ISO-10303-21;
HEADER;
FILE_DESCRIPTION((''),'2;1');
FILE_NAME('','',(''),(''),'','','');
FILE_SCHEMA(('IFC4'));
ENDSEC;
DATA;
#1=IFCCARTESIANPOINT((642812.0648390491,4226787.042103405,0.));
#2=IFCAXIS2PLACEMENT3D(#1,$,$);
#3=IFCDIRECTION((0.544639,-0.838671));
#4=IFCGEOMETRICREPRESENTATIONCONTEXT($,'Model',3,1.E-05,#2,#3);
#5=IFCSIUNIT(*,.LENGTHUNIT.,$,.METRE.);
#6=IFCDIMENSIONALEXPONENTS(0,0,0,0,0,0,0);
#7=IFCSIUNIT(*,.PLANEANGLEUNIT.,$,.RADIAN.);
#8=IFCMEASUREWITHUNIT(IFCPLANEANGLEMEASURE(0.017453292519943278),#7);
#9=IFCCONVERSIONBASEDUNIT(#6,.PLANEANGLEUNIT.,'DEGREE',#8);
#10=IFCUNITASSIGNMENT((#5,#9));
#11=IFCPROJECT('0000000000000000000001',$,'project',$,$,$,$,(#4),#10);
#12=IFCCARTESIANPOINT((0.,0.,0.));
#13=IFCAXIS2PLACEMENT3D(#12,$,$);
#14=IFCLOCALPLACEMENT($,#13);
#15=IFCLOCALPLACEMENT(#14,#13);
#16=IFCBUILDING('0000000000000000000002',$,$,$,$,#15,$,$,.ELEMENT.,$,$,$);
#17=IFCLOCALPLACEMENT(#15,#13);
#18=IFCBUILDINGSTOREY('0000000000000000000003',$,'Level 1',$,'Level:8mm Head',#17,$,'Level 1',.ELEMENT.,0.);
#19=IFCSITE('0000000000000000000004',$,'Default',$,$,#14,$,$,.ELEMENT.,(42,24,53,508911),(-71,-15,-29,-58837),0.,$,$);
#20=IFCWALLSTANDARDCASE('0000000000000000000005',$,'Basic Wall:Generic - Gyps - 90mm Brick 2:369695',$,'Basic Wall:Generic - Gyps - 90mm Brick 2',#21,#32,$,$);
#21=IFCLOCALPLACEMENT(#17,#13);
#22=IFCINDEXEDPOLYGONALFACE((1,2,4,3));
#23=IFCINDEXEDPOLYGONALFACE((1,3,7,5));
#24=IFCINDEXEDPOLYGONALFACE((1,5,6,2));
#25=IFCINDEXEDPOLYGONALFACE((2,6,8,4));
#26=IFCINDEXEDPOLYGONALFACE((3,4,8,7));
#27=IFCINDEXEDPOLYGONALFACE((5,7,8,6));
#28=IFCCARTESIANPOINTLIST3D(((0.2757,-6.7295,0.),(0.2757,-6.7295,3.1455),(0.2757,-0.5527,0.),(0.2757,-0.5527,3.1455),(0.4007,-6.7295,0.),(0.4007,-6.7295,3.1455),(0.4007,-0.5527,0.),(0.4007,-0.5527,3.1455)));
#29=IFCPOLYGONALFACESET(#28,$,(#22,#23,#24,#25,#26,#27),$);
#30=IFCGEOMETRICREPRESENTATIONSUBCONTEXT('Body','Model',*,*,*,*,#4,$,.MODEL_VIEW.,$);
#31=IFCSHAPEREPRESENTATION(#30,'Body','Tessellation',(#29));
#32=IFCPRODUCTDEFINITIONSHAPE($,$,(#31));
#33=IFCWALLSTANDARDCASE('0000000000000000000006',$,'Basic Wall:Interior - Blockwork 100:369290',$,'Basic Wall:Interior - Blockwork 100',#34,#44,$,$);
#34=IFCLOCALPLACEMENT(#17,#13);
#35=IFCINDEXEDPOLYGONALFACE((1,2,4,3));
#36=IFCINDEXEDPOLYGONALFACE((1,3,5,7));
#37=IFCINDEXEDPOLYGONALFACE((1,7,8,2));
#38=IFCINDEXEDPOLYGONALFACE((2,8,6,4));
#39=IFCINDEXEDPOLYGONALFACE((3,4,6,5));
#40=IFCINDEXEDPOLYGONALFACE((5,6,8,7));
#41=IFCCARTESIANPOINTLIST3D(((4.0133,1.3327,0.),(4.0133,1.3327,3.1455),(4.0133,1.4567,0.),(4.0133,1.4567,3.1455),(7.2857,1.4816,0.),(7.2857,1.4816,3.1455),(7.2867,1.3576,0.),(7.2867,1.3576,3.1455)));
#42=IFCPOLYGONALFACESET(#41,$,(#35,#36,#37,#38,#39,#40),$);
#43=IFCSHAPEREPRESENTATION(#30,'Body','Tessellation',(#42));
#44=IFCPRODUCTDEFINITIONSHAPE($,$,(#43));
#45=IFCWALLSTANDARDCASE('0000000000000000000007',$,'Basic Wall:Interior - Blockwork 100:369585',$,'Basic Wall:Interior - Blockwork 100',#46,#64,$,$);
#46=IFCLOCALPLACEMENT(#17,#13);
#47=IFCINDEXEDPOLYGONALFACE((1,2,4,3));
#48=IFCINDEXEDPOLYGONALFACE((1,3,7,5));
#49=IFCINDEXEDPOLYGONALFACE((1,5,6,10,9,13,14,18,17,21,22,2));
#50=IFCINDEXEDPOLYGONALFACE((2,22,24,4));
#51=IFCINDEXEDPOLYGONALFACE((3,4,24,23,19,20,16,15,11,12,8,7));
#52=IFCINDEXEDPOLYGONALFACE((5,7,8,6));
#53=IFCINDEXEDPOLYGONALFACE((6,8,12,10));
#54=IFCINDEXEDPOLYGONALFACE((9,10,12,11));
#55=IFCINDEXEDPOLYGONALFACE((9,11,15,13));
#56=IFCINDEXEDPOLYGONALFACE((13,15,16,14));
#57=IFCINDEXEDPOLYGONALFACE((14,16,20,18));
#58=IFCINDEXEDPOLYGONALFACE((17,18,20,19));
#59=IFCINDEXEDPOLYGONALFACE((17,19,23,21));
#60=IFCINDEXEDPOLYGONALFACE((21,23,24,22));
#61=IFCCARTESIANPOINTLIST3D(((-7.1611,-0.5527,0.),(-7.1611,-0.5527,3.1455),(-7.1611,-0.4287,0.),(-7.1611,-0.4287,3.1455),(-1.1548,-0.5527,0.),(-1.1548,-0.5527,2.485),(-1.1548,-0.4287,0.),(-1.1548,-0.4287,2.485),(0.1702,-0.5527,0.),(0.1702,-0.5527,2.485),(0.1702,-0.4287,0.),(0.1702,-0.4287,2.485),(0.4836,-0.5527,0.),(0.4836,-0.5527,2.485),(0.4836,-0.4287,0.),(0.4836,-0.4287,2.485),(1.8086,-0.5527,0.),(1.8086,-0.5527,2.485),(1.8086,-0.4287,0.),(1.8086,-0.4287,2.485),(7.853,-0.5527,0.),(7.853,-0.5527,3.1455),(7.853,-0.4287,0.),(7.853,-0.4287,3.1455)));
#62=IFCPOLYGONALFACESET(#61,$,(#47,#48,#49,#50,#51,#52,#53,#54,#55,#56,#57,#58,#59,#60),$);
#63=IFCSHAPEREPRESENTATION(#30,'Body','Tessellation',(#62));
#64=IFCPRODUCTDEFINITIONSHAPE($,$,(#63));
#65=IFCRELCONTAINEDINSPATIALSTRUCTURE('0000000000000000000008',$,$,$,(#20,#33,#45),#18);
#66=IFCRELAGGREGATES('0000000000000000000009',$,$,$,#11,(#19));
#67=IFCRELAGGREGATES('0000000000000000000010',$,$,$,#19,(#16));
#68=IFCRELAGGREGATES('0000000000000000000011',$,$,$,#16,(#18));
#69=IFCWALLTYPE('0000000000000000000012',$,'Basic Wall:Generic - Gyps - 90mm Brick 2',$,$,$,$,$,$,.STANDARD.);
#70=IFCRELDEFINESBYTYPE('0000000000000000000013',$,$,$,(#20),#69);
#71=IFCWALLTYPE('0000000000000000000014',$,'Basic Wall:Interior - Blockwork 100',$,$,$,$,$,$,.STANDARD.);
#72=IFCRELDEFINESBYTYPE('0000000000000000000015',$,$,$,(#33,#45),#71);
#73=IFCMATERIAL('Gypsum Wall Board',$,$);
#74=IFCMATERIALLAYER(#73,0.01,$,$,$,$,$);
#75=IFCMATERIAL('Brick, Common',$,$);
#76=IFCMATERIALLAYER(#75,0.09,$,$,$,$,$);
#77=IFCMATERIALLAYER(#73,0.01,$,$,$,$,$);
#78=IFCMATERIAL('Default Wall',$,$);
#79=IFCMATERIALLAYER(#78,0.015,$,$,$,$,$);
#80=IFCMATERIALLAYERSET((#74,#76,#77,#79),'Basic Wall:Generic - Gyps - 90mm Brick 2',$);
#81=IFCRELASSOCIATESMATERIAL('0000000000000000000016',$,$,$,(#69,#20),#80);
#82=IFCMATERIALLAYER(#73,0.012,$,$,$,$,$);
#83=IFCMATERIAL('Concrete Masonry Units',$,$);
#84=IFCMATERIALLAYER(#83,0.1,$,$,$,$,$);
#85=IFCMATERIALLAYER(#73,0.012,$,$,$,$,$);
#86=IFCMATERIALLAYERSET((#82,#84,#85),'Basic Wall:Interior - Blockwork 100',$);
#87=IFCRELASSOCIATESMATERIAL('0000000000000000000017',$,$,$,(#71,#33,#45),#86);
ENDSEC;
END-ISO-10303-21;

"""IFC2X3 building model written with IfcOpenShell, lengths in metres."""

from ifc_helpers import new_model, entity, si_unit, converted_unit, direction, frame, frame_2d, origin, place, context, subcontext, project, spatial, polyline, rectangle, outline, extrude, clip, bounded_halfspace, material, layer, layer_set, layer_usage, type_object, element, save


model = new_model("IFC2X3")

# Units and contexts
model_context = context("Model", 3, precision=1e-05, world=frame((642812.0648390491, 4226787.042103405, 0.0)), true_north=direction((0.544639, -0.838671)))
body_context = subcontext(model_context, "Body", "Model", "MODEL_VIEW")
ifc_project = project(units=[si_unit("LENGTHUNIT", "METRE"), converted_unit("PLANEANGLEUNIT", "DEGREE", entity("IfcPlaneAngleMeasure", 0.017453292519943278), si_unit("PLANEANGLEUNIT", "RADIAN"), dimensions=[0, 0, 0, 0, 0, 0, 0])], contexts=[model_context])

# Site, building, storey
site_placement = place(None, origin())
site = spatial("IfcSite", under=ifc_project, at=site_placement, Name="Default", CompositionType="ELEMENT", RefLatitude=(42, 24, 53, 508911), RefLongitude=(-71, -15, -29, -58837), RefElevation=0.0)
building_placement = place(site_placement, origin())
building = spatial("IfcBuilding", under=site, at=building_placement, CompositionType="ELEMENT")
storey_placement = place(building_placement, origin())
storey = spatial("IfcBuildingStorey", under=building, at=storey_placement, Name="Level 1", ObjectType="Level:8mm Head", LongName="Level 1", CompositionType="ELEMENT", Elevation=0.0)

# Shared definitions
ifc_material_1 = material(Name="Gypsum Wall Board")

# Shared definitions
ifc_material_2 = material(Name="Brick, Common")
ifc_material_3 = material(Name="Default Wall")

# Walls
ifc_layer_1 = layer(ifc_material_1, 0.01)
ifc_layer_2 = layer(ifc_material_2, 0.09)
ifc_layer_3 = layer(ifc_material_1, 0.01)
ifc_layer_4 = layer(ifc_material_3, 0.015)
ifc_layer_set_1 = layer_set([ifc_layer_1, ifc_layer_2, ifc_layer_3, ifc_layer_4], Name="Basic Wall:Generic - Gyps - 90mm Brick 2")
ifc_layer_usage_1 = layer_usage(ifc_layer_set_1, "AXIS2", "NEGATIVE", 0.0625)
wall_type_1 = type_object("IfcWallType", Name="Basic Wall:Generic - Gyps - 90mm Brick 2", PredefinedType="STANDARD", material=ifc_layer_set_1)
wall_1_placement = place(storey_placement, frame((0.3382, -6.7295, 0.0), z_axis=(0.0, 0.0, 1.0), x_axis=(0.0, 1.0, 0.0)))
element("IfcWallStandardCase", 1, at=wall_1_placement, inside=storey, type_object=wall_type_1, material=ifc_layer_usage_1, Name="Basic Wall:Generic - Gyps - 90mm Brick 2:369695", ObjectType="Basic Wall:Generic - Gyps - 90mm Brick 2", context=body_context, shape_type="Clipping", body=[
    clip(extrude(rectangle(XDim=6.1768, YDim=0.125, at=frame_2d((3.0884, 0.0), x_axis=(-1.0, 0.0))), origin(), (0.0, 0.0, 1.0), 3.1455), bounded_halfspace(frame((0.0, -0.0625, 3.1455), z_axis=(0.0, 0.0, -1.0), x_axis=(0.0, -1.0, 0.0)), True, frame((0.0, -0.0625, 3.1455)), polyline([(0.0, 0.0), (6.1768, 0.0), (6.1768, 0.125), (0.0, 0.125), (0.0, 0.0)]))),
])
ifc_layer_5 = layer(ifc_material_1, 0.012)
ifc_material_4 = material(Name="Concrete Masonry Units")
ifc_layer_6 = layer(ifc_material_4, 0.1)
ifc_layer_7 = layer(ifc_material_1, 0.012)
ifc_layer_set_2 = layer_set([ifc_layer_5, ifc_layer_6, ifc_layer_7], Name="Basic Wall:Interior - Blockwork 100")
ifc_layer_usage_2 = layer_usage(ifc_layer_set_2, "AXIS2", "NEGATIVE", 0.062)
wall_type_2 = type_object("IfcWallType", Name="Basic Wall:Interior - Blockwork 100", PredefinedType="STANDARD", material=ifc_layer_set_2)
wall_2_placement = place(storey_placement, frame((7.2862, 1.4196, 0.0), z_axis=(0.0, 0.0, 1.0), x_axis=(-0.999971, -0.007622, 0.0)))
element("IfcWallStandardCase", 2, at=wall_2_placement, inside=storey, type_object=wall_type_2, material=ifc_layer_usage_2, Name="Basic Wall:Interior - Blockwork 100:369290", ObjectType="Basic Wall:Interior - Blockwork 100", context=body_context, shape_type="Clipping", body=[
    clip(extrude(outline(polyline([(3.2725, -0.062), (3.2735, 0.062), (0.0, 0.062), (0.0, -0.062), (3.2725, -0.062)])), origin(), (0.0, 0.0, 1.0), 3.1455), bounded_halfspace(frame((0.0, -0.062, 3.1455), z_axis=(0.0, 0.0, -1.0), x_axis=(-0.999971, 0.007622, 0.0)), True, frame((0.0, -0.062, 3.1455)), polyline([(0.0, 0.0), (3.2725, 0.0), (3.2735, 0.124), (0.0, 0.124), (0.0, 0.0)]))),
])

# Wall, openings
wall_3_placement = place(storey_placement, frame((7.853, -0.4907, 0.0), z_axis=(0.0, 0.0, 1.0), x_axis=(-1.0, 0.0, 0.0)))
wall_3 = element("IfcWallStandardCase", 3, at=wall_3_placement, inside=storey, type_object=wall_type_2, material=ifc_layer_usage_2, Name="Basic Wall:Interior - Blockwork 100:369585", ObjectType="Basic Wall:Interior - Blockwork 100", context=body_context, shape_type="Clipping", body=[
    clip(extrude(rectangle(XDim=15.014, YDim=0.124, at=frame_2d((7.507, 0.0), x_axis=(1.0, 0.0))), origin(), (0.0, 0.0, 1.0), 3.1455), bounded_halfspace(frame((0.0, -0.062, 3.1455), z_axis=(0.0, 0.0, -1.0), x_axis=(-1.0, 0.0, 0.0)), True, frame((0.0, -0.062, 3.1455)), polyline([(0.0, 0.0), (9.148, 0.0), (9.272, 0.0), (15.014, 0.0), (15.014, 0.124), (14.8649, 0.124), (14.4399, 0.124), (10.2889, 0.124), (9.8639, 0.124), (7.5772, 0.124), (7.4522, 0.124), (5.6468, 0.124), (5.3468, 0.124), (0.5062, 0.124), (0.1062, 0.124), (0.0, 0.124), (0.0, 0.0)]))),
])
opening_1_placement = place(wall_3_placement, frame((6.0444, -0.062, 0.0)))
element("IfcOpeningElement", 4, at=opening_1_placement, cuts=wall_3, ObjectType="Opening", context=body_context, shape_type="SweptSolid", body=[
    extrude(rectangle(XDim=2.485, YDim=1.325, at=frame_2d((1.2425, 0.6625), x_axis=(1.0, 0.0))), frame((0.0, 0.0, 0.0), z_axis=(0.0, 1.0, 0.0), x_axis=(0.0, 0.0, 1.0)), (0.0, 0.0, 1.0), 0.124),
])
opening_2_placement = place(wall_3_placement, frame((7.6828, -0.062, 0.0)))
element("IfcOpeningElement", 5, at=opening_2_placement, cuts=wall_3, ObjectType="Opening", context=body_context, shape_type="SweptSolid", body=[
    extrude(rectangle(XDim=2.485, YDim=1.325, at=frame_2d((1.2425, 0.6625), x_axis=(1.0, 0.0))), frame((0.0, 0.0, 0.0), z_axis=(0.0, 1.0, 0.0), x_axis=(0.0, 0.0, 1.0)), (0.0, 0.0, 1.0), 0.124),
])

save(model, "model.ifc")
